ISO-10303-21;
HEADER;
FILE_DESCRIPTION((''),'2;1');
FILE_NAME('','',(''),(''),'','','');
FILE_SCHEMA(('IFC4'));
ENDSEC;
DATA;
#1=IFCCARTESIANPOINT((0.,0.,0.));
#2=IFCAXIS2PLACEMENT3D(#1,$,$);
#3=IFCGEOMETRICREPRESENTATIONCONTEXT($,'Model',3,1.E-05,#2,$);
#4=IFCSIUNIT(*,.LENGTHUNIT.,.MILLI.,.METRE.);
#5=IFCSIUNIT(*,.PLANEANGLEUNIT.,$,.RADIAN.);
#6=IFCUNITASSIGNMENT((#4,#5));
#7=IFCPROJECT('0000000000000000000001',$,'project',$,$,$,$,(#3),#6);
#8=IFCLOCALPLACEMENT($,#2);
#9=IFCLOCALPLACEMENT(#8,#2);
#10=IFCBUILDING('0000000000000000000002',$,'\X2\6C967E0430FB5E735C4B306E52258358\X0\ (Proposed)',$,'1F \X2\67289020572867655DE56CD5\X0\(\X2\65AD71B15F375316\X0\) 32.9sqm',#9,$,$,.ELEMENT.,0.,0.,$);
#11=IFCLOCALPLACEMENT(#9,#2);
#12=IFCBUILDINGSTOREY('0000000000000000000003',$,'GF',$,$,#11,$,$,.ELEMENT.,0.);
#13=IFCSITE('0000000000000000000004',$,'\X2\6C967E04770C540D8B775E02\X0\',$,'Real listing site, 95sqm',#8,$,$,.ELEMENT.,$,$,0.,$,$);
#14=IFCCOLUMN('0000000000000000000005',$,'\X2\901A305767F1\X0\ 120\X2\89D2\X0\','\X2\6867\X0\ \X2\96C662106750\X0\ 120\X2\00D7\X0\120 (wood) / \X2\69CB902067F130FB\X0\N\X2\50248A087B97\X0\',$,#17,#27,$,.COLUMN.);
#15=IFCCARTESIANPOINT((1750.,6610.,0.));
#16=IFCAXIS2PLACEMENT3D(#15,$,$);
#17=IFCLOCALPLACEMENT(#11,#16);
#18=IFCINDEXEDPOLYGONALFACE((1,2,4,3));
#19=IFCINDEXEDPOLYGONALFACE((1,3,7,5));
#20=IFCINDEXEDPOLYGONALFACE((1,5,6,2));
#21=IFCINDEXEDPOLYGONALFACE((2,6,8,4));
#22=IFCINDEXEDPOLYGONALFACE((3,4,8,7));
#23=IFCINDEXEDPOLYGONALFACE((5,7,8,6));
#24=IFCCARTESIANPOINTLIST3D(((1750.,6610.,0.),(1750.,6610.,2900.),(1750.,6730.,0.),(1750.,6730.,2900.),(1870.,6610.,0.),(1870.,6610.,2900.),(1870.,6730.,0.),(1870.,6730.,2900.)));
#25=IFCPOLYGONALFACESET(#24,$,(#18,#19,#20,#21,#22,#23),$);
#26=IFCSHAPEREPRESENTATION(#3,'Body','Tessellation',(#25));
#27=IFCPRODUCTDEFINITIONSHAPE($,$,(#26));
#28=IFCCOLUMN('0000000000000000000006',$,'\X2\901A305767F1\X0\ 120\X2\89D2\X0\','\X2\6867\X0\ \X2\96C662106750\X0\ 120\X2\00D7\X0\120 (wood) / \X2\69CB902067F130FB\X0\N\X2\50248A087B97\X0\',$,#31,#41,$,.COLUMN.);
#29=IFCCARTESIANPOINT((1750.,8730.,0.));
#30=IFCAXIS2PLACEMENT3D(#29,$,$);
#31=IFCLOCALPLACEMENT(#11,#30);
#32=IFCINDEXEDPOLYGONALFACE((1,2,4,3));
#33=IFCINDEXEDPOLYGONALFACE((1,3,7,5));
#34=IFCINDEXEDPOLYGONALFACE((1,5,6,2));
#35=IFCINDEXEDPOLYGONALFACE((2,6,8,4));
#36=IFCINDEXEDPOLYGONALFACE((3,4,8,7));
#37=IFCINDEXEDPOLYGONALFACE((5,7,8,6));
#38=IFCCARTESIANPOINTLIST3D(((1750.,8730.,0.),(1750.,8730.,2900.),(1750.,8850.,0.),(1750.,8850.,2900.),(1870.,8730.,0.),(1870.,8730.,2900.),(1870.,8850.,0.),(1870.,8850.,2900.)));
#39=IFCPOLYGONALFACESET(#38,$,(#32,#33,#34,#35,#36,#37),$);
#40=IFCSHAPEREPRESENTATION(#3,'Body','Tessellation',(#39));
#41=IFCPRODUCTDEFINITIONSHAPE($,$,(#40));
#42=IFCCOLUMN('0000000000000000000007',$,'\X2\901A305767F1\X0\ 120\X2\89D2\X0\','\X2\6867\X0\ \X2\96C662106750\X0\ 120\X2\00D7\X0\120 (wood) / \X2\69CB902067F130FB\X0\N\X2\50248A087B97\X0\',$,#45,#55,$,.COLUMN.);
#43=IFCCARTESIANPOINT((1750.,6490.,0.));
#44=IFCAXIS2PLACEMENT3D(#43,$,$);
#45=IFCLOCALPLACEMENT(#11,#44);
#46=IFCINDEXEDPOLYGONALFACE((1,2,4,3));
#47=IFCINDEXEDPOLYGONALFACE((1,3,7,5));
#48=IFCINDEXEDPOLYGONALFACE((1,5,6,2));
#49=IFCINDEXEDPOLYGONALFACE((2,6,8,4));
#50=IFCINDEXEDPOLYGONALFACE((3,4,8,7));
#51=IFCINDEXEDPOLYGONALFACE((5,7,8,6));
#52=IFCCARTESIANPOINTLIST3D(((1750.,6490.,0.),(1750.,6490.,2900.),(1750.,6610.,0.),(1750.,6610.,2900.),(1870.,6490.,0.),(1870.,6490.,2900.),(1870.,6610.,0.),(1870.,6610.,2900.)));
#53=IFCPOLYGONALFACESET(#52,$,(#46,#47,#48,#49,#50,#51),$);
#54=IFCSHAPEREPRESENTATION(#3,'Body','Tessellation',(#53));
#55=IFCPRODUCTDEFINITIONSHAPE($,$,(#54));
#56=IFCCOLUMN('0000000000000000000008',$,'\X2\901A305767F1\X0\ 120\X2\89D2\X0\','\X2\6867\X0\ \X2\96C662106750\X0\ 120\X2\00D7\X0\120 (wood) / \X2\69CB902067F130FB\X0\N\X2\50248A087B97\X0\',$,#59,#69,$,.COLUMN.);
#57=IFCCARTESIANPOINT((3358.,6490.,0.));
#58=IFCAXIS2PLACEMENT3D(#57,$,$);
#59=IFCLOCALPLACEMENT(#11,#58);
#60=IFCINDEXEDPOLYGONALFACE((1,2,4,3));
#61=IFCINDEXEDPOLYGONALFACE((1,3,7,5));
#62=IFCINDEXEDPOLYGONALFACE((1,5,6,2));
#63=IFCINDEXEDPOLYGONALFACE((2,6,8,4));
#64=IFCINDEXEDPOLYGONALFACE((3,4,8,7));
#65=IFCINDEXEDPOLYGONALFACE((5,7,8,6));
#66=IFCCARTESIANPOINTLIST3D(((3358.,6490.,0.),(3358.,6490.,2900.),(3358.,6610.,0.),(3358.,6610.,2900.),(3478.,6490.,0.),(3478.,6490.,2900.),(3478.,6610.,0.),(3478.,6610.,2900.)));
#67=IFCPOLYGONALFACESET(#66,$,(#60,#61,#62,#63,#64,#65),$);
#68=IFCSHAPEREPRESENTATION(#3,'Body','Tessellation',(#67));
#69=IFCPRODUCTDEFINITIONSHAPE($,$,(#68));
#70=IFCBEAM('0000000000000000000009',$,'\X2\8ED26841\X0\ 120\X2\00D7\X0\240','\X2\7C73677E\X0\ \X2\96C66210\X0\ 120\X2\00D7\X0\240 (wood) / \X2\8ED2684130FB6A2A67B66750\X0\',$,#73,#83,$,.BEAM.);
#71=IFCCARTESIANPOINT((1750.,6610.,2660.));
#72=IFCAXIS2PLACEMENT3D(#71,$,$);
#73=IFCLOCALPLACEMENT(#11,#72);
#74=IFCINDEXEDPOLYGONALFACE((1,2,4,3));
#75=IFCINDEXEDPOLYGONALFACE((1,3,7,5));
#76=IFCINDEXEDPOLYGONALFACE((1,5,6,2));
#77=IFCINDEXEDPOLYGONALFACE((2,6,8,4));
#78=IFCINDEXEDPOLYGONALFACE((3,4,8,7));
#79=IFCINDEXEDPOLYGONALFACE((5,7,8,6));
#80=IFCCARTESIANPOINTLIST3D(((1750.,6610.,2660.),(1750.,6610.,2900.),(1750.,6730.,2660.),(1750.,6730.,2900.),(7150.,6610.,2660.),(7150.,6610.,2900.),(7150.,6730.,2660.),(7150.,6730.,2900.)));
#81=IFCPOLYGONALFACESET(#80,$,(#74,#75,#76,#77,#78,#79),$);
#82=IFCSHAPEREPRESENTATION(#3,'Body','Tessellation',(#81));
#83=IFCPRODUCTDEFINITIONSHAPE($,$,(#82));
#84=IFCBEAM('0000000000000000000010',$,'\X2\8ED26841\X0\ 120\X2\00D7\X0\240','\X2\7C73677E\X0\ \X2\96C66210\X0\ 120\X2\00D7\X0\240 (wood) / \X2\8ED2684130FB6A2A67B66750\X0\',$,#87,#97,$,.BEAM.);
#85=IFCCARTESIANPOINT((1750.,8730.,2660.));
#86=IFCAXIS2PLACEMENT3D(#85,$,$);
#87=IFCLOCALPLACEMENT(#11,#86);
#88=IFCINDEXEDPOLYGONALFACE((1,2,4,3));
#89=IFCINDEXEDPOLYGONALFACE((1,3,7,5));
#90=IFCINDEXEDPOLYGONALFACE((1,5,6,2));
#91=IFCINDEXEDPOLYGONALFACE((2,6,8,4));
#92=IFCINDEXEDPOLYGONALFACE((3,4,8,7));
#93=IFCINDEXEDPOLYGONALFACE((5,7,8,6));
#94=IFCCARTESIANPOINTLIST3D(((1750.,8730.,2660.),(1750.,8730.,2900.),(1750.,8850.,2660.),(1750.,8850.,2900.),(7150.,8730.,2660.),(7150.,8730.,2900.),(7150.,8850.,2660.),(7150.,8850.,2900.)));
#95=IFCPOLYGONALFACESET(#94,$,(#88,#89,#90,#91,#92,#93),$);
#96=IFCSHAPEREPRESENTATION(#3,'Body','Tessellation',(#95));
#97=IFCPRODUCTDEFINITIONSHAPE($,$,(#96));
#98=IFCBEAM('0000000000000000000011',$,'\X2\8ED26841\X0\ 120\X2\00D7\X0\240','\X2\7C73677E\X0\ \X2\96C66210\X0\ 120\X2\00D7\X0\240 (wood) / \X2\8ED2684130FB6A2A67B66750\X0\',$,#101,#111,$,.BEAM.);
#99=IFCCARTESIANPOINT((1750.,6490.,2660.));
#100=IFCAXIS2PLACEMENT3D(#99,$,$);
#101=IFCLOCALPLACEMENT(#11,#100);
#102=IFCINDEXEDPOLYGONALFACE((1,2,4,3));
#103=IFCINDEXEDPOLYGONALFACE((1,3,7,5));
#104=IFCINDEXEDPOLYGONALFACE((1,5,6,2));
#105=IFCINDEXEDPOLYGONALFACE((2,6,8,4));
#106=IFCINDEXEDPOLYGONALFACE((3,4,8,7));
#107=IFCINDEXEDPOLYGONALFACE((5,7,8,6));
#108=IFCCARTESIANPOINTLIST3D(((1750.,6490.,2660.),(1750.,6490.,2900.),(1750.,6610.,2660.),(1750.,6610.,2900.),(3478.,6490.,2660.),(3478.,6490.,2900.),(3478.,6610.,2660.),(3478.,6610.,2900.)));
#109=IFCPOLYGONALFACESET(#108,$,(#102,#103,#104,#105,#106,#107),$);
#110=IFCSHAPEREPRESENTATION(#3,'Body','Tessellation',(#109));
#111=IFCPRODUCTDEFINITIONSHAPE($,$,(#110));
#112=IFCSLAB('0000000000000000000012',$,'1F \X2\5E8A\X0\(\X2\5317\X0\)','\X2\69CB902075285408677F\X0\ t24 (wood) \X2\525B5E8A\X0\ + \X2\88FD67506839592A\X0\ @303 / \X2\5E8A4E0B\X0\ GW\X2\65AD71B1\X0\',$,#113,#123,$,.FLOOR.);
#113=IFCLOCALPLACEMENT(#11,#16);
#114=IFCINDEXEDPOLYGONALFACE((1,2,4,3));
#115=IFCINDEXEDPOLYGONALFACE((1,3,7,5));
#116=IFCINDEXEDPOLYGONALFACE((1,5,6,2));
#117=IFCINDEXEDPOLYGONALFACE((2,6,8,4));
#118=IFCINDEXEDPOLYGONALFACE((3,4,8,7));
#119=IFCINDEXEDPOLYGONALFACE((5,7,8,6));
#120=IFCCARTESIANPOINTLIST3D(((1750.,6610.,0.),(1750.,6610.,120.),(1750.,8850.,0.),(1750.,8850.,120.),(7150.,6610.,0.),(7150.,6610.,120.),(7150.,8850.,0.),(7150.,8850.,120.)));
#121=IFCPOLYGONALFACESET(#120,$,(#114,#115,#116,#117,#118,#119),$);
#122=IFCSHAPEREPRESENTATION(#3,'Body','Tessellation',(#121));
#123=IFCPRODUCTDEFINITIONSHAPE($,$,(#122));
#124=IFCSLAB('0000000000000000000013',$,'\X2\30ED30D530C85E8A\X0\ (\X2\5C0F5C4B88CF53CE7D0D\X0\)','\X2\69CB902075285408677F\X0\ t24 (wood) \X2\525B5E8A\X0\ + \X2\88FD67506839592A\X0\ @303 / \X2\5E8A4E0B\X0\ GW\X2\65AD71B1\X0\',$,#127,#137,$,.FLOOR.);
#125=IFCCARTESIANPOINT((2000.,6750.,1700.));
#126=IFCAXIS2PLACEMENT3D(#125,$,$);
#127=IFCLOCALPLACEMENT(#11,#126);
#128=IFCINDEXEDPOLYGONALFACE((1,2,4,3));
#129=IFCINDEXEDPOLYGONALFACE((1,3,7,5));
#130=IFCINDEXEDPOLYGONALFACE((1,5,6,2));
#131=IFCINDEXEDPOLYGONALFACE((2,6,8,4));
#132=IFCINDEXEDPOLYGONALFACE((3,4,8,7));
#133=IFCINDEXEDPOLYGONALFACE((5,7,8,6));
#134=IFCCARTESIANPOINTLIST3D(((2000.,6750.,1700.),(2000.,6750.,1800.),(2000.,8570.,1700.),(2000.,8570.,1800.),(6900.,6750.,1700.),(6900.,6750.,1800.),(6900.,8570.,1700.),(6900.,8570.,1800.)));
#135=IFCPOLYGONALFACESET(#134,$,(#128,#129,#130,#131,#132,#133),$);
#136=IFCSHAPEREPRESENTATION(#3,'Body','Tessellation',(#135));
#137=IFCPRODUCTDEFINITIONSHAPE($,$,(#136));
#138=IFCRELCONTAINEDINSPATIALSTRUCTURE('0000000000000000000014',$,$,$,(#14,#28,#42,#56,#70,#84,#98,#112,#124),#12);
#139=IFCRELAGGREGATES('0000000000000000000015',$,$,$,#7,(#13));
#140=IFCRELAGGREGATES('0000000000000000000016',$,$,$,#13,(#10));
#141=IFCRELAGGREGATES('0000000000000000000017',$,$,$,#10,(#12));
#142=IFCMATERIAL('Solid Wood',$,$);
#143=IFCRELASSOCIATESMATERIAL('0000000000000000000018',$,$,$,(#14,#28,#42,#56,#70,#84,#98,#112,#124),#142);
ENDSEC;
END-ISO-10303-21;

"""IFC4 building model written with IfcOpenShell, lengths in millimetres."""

from ifc_helpers import new_model, si_unit, frame, frame_2d, origin, place, context, project, spatial, rectangle, extrude, material, element, save


model = new_model("IFC4")

# Units and contexts
model_context = context("Model", 3, precision=1e-05, world=origin())
ifc_project = project(units=[si_unit("LENGTHUNIT", "METRE", prefix="MILLI"), si_unit("PLANEANGLEUNIT", "RADIAN")], contexts=[model_context])

# Site, building, storey
site_placement = place(None, origin())
site = spatial("IfcSite", under=ifc_project, at=site_placement, Name="沖縄県名護市", ObjectType="Real listing site, 95sqm", CompositionType="ELEMENT", RefElevation=0.0)
building_placement = place(site_placement, origin())
building = spatial("IfcBuilding", under=site, at=building_placement, Name="沖縄・平屋の別荘 (Proposed)", ObjectType="1F 木造在来工法(断熱強化) 32.9sqm", CompositionType="ELEMENT", ElevationOfRefHeight=0.0, ElevationOfTerrain=0.0)
storey_placement = place(building_placement, origin())
storey = spatial("IfcBuildingStorey", under=building, at=storey_placement, Name="GF", CompositionType="ELEMENT", Elevation=0.0)

# Columns
ifc_material_1 = material(Name="Solid Wood")
column_1_placement = place(storey_placement, frame((1750.0, 6610.0, 0.0)))
element("IfcColumn", 1, at=column_1_placement, inside=storey, material=ifc_material_1, Name="通し柱 120角", Description="桧 集成材 120×120 (wood) / 構造柱・N値計算", PredefinedType="COLUMN", context=model_context, shape_type="SweptSolid", body=[
    extrude(rectangle(XDim=120.0, YDim=120.0, at=frame_2d((60.0, 60.0))), frame((1750.0, 6610.0, 0.0)), (0.0, 0.0, 1.0), 2900.0),
])
column_2_placement = place(storey_placement, frame((1750.0, 8730.0, 0.0)))
element("IfcColumn", 2, at=column_2_placement, inside=storey, material=ifc_material_1, Name="通し柱 120角", Description="桧 集成材 120×120 (wood) / 構造柱・N値計算", PredefinedType="COLUMN", context=model_context, shape_type="SweptSolid", body=[
    extrude(rectangle(XDim=120.0, YDim=120.0, at=frame_2d((60.0, 60.0))), frame((1750.0, 8730.0, 0.0)), (0.0, 0.0, 1.0), 2900.0),
])
column_3_placement = place(storey_placement, frame((1750.0, 6490.0, 0.0)))
element("IfcColumn", 3, at=column_3_placement, inside=storey, material=ifc_material_1, Name="通し柱 120角", Description="桧 集成材 120×120 (wood) / 構造柱・N値計算", PredefinedType="COLUMN", context=model_context, shape_type="SweptSolid", body=[
    extrude(rectangle(XDim=120.0, YDim=120.0, at=frame_2d((60.0, 60.0))), frame((1750.0, 6490.0, 0.0)), (0.0, 0.0, 1.0), 2900.0),
])
column_4_placement = place(storey_placement, frame((3358.0, 6490.0, 0.0)))
element("IfcColumn", 4, at=column_4_placement, inside=storey, material=ifc_material_1, Name="通し柱 120角", Description="桧 集成材 120×120 (wood) / 構造柱・N値計算", PredefinedType="COLUMN", context=model_context, shape_type="SweptSolid", body=[
    extrude(rectangle(XDim=120.0, YDim=120.0, at=frame_2d((60.0, 60.0))), frame((3358.0, 6490.0, 0.0)), (0.0, 0.0, 1.0), 2900.0),
])

# Beams
beam_1_placement = place(storey_placement, frame((1750.0, 6610.0, 2660.0)))
element("IfcBeam", 5, at=beam_1_placement, inside=storey, material=ifc_material_1, Name="軒桁 120×240", Description="米松 集成 120×240 (wood) / 軒桁・横架材", PredefinedType="BEAM", context=model_context, shape_type="SweptSolid", body=[
    extrude(rectangle(XDim=5400.0, YDim=120.0, at=frame_2d((2700.0, 60.0))), frame((1750.0, 6610.0, 2660.0)), (0.0, 0.0, 1.0), 240.0),
])
beam_2_placement = place(storey_placement, frame((1750.0, 8730.0, 2660.0)))
element("IfcBeam", 6, at=beam_2_placement, inside=storey, material=ifc_material_1, Name="軒桁 120×240", Description="米松 集成 120×240 (wood) / 軒桁・横架材", PredefinedType="BEAM", context=model_context, shape_type="SweptSolid", body=[
    extrude(rectangle(XDim=5400.0, YDim=120.0, at=frame_2d((2700.0, 60.0))), frame((1750.0, 8730.0, 2660.0)), (0.0, 0.0, 1.0), 240.0),
])
beam_3_placement = place(storey_placement, frame((1750.0, 6490.0, 2660.0)))
element("IfcBeam", 7, at=beam_3_placement, inside=storey, material=ifc_material_1, Name="軒桁 120×240", Description="米松 集成 120×240 (wood) / 軒桁・横架材", PredefinedType="BEAM", context=model_context, shape_type="SweptSolid", body=[
    extrude(rectangle(XDim=1728.0, YDim=120.0, at=frame_2d((864.0, 60.0))), frame((1750.0, 6490.0, 2660.0)), (0.0, 0.0, 1.0), 240.0),
])

# Slabs
slab_1_placement = place(storey_placement, frame((1750.0, 6610.0, 0.0)))
element("IfcSlab", 8, at=slab_1_placement, inside=storey, material=ifc_material_1, Name="1F 床(北)", Description="構造用合板 t24 (wood) 剛床 + 製材根太 @303 / 床下 GW断熱", PredefinedType="FLOOR", context=model_context, shape_type="SweptSolid", body=[
    extrude(rectangle(XDim=5400.0, YDim=2240.0, at=frame_2d((2700.0, 1120.0))), frame((1750.0, 6610.0, 0.0)), (0.0, 0.0, 1.0), 120.0),
])
slab_2_placement = place(storey_placement, frame((2000.0, 6750.0, 1700.0)))
element("IfcSlab", 9, at=slab_2_placement, inside=storey, material=ifc_material_1, Name="ロフト床 (小屋裏収納)", Description="構造用合板 t24 (wood) 剛床 + 製材根太 @303 / 床下 GW断熱", PredefinedType="FLOOR", context=model_context, shape_type="SweptSolid", body=[
    extrude(rectangle(XDim=4900.0, YDim=1820.0, at=frame_2d((2450.0, 910.0))), frame((2000.0, 6750.0, 1700.0)), (0.0, 0.0, 1.0), 100.0),
])

save(model, "model.ifc")
